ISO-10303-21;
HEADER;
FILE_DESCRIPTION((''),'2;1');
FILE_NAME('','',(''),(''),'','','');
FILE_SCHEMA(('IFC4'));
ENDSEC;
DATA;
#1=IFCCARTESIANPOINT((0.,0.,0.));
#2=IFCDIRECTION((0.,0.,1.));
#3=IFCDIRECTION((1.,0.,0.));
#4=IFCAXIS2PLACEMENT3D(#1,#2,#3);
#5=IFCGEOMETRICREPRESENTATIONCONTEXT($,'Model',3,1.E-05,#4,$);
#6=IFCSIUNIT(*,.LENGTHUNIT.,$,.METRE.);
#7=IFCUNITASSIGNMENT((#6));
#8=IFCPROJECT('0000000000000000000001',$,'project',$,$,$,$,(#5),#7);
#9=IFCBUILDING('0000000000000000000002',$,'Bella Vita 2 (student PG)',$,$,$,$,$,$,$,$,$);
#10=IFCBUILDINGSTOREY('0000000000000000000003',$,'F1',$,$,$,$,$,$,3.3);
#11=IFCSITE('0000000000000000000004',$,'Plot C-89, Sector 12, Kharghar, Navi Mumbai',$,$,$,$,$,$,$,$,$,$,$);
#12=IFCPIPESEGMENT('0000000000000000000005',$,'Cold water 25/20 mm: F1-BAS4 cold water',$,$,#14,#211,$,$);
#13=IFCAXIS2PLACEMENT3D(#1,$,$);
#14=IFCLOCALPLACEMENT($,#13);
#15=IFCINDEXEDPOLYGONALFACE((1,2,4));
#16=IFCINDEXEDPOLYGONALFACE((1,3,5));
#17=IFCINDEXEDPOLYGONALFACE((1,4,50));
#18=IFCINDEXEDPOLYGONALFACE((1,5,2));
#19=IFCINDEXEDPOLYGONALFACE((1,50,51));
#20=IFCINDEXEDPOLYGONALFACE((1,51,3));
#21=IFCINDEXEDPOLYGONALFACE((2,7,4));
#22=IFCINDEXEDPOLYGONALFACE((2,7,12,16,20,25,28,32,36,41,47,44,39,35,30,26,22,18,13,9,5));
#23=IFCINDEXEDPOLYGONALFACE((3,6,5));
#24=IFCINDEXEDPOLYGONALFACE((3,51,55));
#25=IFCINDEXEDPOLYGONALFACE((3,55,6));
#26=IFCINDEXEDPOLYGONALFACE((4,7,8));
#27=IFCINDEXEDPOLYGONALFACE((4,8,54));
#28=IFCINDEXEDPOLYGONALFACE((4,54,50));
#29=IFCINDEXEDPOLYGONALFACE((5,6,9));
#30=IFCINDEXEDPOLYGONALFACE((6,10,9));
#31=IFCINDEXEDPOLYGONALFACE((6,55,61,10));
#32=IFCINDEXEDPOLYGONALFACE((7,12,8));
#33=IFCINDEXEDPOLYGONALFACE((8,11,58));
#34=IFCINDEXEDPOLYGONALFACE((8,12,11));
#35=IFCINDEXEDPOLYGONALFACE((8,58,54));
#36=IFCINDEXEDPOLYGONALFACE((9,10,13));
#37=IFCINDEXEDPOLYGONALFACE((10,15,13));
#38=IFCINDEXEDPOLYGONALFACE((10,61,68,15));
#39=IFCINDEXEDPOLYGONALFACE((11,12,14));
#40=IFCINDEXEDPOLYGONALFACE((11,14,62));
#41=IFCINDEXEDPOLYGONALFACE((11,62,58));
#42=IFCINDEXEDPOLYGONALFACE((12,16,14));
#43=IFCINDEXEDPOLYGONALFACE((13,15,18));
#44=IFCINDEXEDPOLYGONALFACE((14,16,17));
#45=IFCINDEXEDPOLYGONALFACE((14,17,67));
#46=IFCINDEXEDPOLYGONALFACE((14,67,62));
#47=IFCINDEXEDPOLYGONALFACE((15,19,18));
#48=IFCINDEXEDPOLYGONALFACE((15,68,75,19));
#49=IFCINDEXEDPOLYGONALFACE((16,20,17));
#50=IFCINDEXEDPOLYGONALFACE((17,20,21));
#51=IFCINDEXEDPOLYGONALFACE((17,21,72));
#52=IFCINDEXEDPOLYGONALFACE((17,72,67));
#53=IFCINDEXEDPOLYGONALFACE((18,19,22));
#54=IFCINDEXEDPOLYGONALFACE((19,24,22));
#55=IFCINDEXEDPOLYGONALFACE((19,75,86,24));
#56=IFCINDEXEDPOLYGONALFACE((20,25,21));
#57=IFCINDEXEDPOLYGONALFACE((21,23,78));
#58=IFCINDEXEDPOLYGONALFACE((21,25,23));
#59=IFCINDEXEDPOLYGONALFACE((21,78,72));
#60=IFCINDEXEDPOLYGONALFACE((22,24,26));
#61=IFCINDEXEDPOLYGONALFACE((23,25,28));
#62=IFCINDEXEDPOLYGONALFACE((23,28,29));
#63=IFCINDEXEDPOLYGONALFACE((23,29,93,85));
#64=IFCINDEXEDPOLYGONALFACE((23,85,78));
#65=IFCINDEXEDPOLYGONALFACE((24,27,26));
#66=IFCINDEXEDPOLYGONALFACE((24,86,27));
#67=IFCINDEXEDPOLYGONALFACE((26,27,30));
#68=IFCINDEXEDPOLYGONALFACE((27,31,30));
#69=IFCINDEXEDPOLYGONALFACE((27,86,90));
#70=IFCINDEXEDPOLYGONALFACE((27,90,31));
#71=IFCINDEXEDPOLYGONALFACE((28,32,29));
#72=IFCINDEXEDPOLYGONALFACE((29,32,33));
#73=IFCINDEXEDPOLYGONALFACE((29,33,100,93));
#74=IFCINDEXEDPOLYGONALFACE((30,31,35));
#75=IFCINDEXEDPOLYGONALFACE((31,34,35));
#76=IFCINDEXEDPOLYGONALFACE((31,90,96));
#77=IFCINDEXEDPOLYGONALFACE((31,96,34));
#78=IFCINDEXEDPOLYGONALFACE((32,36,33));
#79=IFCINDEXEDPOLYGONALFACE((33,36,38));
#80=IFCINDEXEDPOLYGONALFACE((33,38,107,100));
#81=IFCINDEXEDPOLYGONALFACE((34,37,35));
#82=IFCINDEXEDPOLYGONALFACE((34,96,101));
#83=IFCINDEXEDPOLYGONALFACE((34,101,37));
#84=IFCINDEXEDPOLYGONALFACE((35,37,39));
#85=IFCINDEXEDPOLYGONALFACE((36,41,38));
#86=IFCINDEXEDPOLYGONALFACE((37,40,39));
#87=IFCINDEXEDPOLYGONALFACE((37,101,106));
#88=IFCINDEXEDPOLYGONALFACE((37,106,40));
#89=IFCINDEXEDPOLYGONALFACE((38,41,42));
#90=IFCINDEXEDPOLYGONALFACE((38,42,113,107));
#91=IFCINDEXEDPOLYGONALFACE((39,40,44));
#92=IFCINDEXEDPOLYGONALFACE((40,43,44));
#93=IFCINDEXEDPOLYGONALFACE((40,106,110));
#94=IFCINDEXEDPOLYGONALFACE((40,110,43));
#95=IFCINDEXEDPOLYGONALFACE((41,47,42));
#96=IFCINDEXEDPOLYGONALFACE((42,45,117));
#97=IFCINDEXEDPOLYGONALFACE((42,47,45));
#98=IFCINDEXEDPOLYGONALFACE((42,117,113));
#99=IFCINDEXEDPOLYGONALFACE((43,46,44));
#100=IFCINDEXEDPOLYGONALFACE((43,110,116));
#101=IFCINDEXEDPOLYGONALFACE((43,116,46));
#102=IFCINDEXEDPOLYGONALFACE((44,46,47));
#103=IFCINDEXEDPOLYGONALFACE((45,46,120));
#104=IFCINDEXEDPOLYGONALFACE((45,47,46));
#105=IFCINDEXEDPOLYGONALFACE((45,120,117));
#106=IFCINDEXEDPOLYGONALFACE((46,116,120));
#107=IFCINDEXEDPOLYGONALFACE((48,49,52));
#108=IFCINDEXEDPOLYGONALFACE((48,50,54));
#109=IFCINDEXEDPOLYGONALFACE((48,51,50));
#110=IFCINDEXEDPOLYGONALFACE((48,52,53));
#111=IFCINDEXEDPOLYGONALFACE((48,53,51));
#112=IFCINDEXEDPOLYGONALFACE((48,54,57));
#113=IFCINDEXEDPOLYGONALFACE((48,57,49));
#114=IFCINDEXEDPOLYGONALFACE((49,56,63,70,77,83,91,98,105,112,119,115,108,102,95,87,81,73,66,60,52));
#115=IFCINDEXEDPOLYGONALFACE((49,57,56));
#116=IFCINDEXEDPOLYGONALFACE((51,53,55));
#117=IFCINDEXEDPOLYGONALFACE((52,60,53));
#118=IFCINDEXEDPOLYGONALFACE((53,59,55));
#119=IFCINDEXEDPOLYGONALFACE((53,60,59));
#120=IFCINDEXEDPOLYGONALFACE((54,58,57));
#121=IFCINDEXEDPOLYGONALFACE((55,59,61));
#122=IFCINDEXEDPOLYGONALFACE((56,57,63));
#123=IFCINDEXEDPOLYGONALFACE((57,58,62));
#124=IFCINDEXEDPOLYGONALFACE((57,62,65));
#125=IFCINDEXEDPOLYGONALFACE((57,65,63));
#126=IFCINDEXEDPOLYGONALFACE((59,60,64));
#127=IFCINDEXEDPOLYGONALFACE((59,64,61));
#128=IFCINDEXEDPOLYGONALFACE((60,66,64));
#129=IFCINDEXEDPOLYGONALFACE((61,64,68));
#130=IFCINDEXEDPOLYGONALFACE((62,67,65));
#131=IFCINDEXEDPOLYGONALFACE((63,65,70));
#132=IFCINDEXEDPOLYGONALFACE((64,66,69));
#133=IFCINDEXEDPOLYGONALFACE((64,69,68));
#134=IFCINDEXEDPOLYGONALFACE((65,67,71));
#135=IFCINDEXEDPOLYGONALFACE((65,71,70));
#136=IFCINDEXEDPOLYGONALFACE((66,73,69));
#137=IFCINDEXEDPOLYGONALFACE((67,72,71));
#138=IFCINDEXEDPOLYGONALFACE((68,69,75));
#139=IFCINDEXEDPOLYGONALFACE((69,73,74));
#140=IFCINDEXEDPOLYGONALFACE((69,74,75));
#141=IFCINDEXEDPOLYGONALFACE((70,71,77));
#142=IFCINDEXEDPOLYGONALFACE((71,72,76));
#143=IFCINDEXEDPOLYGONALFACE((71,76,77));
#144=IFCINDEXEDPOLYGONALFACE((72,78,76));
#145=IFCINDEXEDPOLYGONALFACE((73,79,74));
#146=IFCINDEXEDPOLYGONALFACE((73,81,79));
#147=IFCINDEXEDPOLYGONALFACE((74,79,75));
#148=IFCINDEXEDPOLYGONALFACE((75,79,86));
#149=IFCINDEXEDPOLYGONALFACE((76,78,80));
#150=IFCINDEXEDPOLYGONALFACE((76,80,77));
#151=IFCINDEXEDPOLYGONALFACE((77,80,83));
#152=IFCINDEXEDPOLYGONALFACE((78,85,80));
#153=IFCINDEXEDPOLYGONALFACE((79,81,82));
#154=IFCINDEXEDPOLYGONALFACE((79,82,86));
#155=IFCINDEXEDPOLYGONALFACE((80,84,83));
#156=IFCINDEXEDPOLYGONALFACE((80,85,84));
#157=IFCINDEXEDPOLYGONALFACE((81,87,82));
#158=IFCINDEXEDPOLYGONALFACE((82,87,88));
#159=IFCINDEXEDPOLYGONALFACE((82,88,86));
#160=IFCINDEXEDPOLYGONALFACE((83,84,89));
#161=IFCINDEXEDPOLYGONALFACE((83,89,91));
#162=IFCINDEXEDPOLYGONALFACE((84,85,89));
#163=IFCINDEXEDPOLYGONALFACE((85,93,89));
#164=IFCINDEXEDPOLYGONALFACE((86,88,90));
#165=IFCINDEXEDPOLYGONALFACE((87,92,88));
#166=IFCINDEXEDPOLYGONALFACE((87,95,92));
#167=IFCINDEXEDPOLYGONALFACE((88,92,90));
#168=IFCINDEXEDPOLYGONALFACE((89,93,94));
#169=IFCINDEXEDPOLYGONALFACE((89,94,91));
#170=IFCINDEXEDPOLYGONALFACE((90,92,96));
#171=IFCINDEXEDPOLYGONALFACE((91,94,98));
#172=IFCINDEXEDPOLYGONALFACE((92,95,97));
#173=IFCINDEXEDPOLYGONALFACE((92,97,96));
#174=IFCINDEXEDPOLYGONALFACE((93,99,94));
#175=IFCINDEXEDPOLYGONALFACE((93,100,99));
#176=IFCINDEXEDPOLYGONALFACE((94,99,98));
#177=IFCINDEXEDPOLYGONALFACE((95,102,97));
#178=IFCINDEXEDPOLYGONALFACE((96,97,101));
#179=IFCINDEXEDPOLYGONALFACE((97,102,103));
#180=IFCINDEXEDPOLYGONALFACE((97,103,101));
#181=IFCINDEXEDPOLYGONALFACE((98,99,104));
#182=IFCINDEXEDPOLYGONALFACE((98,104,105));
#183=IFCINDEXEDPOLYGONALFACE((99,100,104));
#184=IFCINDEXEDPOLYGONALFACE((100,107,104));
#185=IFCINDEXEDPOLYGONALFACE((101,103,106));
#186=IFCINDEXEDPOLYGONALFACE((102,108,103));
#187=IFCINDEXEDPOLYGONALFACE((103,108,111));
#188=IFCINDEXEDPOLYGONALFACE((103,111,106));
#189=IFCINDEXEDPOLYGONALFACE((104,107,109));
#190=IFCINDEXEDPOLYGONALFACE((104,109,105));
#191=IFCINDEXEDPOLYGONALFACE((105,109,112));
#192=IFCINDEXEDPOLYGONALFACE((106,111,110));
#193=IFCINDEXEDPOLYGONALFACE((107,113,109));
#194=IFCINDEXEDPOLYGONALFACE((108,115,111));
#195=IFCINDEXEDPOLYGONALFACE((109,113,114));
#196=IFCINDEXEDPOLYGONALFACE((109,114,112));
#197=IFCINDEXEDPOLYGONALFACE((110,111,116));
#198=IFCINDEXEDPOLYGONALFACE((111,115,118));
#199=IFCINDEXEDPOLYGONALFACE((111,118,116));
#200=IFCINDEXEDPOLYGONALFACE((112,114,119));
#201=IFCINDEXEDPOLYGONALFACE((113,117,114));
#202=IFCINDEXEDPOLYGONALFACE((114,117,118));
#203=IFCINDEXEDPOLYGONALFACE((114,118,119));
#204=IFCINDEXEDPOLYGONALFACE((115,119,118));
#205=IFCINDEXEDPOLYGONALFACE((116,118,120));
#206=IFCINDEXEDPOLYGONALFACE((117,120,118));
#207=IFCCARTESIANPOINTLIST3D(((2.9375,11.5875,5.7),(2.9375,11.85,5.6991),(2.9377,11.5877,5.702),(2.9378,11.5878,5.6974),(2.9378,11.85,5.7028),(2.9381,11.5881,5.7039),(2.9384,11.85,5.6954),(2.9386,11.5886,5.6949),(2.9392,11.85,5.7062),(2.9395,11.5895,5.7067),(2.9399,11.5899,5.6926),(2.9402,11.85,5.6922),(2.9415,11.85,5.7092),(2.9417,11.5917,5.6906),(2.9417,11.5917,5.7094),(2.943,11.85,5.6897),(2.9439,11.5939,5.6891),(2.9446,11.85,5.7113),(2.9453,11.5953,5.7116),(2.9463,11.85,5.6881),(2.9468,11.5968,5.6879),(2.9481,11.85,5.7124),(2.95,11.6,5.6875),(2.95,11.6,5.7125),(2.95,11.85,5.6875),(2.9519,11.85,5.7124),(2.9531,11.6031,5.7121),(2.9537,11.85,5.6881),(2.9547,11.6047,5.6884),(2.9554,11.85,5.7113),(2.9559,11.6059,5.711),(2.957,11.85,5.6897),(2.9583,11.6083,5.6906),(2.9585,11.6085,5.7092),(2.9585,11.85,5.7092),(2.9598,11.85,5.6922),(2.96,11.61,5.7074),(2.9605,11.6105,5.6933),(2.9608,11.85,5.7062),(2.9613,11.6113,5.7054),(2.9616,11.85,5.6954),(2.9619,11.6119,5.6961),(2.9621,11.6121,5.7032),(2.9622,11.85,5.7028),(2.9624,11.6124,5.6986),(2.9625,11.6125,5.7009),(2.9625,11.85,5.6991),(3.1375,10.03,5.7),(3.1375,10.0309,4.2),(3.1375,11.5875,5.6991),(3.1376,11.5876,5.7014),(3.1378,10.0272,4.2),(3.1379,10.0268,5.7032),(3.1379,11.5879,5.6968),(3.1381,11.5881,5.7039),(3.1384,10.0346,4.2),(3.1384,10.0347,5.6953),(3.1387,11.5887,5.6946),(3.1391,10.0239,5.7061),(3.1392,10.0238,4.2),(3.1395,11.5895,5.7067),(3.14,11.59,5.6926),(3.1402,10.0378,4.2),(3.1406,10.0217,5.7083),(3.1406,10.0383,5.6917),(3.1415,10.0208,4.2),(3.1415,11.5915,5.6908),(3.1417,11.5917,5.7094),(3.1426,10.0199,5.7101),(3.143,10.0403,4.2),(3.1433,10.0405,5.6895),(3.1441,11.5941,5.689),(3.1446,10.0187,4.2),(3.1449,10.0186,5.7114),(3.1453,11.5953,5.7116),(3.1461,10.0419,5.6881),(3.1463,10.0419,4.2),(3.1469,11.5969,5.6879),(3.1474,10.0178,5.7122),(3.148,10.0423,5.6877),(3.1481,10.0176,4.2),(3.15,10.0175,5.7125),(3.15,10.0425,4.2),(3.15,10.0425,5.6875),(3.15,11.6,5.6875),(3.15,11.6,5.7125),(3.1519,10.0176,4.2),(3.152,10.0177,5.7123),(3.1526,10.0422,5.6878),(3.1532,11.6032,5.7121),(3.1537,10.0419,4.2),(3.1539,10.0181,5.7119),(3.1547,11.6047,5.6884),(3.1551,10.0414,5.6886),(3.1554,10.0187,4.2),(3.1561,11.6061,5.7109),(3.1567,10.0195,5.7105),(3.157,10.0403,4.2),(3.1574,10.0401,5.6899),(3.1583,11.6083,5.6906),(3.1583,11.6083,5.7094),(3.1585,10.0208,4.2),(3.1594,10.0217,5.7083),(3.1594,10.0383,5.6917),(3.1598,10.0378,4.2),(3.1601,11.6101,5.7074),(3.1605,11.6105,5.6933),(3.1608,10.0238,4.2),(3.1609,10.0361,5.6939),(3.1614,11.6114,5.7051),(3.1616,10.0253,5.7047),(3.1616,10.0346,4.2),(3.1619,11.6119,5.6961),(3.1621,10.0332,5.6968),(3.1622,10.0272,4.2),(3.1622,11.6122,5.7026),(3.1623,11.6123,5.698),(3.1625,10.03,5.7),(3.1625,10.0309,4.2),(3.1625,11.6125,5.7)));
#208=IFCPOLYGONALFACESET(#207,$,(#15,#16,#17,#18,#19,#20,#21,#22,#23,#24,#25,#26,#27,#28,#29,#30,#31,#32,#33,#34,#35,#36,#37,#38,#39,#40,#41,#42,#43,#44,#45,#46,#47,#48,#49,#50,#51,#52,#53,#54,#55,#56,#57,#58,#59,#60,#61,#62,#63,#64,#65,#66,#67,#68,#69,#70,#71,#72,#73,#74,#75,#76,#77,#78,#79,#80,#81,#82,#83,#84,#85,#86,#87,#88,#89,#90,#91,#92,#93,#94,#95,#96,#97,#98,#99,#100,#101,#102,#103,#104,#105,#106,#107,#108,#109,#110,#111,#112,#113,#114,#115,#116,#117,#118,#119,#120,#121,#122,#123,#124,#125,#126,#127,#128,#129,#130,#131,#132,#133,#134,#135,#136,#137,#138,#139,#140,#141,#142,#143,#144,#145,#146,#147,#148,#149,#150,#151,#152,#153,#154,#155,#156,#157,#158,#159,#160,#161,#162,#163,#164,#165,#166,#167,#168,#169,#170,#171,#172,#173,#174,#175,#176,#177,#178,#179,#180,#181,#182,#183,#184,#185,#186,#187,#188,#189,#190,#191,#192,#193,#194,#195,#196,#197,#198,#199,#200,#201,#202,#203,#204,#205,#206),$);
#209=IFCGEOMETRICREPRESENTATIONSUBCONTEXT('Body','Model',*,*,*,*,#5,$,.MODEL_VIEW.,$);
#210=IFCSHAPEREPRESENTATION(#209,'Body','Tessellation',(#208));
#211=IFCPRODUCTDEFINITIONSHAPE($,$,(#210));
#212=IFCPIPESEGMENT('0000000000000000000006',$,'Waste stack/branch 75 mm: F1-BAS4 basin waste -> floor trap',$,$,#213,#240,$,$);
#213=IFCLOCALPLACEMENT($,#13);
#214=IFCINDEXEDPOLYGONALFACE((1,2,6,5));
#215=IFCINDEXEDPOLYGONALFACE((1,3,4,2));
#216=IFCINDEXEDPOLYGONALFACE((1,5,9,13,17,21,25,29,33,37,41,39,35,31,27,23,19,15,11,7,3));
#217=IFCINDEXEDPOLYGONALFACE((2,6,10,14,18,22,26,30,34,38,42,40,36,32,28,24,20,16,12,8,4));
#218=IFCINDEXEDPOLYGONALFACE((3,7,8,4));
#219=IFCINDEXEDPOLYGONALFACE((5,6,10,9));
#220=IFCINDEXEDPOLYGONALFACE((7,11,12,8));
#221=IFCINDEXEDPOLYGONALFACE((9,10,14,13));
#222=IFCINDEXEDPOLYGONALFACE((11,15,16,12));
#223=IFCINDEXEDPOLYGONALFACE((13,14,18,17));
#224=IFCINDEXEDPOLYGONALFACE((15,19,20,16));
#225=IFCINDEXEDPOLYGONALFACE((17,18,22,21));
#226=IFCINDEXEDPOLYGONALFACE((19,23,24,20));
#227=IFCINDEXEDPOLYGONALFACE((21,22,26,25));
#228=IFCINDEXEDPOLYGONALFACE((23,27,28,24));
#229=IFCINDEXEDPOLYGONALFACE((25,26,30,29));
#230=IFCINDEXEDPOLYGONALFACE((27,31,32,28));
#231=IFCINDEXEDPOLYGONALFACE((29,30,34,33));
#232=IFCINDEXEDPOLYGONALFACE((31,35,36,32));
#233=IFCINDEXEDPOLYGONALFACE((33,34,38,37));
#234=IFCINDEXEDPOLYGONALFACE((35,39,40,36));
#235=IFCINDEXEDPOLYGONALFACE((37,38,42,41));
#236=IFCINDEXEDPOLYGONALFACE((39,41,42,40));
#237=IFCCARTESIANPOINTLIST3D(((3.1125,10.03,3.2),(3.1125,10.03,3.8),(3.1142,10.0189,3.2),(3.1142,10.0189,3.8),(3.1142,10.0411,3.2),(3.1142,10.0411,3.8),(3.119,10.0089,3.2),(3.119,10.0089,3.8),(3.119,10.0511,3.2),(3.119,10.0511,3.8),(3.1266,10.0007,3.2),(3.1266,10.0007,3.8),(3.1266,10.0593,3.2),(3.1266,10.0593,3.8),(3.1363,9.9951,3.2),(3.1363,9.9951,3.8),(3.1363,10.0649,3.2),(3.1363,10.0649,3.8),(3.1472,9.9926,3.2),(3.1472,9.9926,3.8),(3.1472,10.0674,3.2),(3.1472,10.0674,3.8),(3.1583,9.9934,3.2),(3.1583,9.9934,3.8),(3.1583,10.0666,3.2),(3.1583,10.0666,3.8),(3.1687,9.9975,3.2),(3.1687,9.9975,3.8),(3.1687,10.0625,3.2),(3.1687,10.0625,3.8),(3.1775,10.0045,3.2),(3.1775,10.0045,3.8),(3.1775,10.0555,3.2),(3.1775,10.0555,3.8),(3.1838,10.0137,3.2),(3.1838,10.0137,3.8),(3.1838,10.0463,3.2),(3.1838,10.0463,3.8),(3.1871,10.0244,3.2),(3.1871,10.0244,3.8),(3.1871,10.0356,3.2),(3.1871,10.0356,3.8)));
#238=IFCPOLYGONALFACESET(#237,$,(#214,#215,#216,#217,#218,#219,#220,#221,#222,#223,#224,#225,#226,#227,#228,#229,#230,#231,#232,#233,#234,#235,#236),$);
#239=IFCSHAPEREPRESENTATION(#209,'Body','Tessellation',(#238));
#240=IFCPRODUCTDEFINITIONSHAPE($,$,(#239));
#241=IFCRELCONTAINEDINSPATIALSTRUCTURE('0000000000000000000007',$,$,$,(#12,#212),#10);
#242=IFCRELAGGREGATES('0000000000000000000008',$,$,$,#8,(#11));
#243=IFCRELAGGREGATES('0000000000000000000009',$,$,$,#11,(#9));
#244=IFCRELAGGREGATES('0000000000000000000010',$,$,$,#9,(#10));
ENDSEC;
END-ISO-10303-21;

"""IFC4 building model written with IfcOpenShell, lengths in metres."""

from ifc_helpers import new_model, entity, si_unit, origin, origin_with_axes, place, context, subcontext, project, spatial, element, save


model = new_model("IFC4")

# Units and contexts
model_context = context("Model", 3, precision=1e-05, world=origin_with_axes())
body_context = subcontext(model_context, "Body", "Model", "MODEL_VIEW")
ifc_project = project(units=[si_unit("LENGTHUNIT", "METRE")], contexts=[model_context])

# Site, building, storey
site = spatial("IfcSite", under=ifc_project, Name="Plot C-89, Sector 12, Kharghar, Navi Mumbai")
building = spatial("IfcBuilding", under=site, Name="Bella Vita 2 (student PG)")
storey = spatial("IfcBuildingStorey", under=building, Name="F1", Elevation=3.3)

# Pipe segments
pipe_segment_1_placement = place(None, origin())
element("IfcPipeSegment", 1, at=pipe_segment_1_placement, inside=storey, Name="Cold water 25/20 mm: F1-BAS4 cold water", context=body_context, shape_type="AdvancedSweptSolid", body=[
    entity("IfcSweptDiskSolid", entity("IfcPolyline", [entity("IfcCartesianPoint", [2.95, 11.85, 5.7]), entity("IfcCartesianPoint", [2.95, 11.6, 5.7]), entity("IfcCartesianPoint", [3.15, 11.6, 5.7]), entity("IfcCartesianPoint", [3.15, 10.03, 5.7]), entity("IfcCartesianPoint", [3.15, 10.03, 4.2])]), 0.0125),
])
pipe_segment_2_placement = place(None, origin())
element("IfcPipeSegment", 2, at=pipe_segment_2_placement, inside=storey, Name="Waste stack/branch 75 mm: F1-BAS4 basin waste -> floor trap", context=body_context, shape_type="AdvancedSweptSolid", body=[
    entity("IfcSweptDiskSolid", entity("IfcPolyline", [entity("IfcCartesianPoint", [3.15, 10.03, 3.8]), entity("IfcCartesianPoint", [3.15, 10.03, 3.2])]), 0.0375),
])

save(model, "model.ifc")
